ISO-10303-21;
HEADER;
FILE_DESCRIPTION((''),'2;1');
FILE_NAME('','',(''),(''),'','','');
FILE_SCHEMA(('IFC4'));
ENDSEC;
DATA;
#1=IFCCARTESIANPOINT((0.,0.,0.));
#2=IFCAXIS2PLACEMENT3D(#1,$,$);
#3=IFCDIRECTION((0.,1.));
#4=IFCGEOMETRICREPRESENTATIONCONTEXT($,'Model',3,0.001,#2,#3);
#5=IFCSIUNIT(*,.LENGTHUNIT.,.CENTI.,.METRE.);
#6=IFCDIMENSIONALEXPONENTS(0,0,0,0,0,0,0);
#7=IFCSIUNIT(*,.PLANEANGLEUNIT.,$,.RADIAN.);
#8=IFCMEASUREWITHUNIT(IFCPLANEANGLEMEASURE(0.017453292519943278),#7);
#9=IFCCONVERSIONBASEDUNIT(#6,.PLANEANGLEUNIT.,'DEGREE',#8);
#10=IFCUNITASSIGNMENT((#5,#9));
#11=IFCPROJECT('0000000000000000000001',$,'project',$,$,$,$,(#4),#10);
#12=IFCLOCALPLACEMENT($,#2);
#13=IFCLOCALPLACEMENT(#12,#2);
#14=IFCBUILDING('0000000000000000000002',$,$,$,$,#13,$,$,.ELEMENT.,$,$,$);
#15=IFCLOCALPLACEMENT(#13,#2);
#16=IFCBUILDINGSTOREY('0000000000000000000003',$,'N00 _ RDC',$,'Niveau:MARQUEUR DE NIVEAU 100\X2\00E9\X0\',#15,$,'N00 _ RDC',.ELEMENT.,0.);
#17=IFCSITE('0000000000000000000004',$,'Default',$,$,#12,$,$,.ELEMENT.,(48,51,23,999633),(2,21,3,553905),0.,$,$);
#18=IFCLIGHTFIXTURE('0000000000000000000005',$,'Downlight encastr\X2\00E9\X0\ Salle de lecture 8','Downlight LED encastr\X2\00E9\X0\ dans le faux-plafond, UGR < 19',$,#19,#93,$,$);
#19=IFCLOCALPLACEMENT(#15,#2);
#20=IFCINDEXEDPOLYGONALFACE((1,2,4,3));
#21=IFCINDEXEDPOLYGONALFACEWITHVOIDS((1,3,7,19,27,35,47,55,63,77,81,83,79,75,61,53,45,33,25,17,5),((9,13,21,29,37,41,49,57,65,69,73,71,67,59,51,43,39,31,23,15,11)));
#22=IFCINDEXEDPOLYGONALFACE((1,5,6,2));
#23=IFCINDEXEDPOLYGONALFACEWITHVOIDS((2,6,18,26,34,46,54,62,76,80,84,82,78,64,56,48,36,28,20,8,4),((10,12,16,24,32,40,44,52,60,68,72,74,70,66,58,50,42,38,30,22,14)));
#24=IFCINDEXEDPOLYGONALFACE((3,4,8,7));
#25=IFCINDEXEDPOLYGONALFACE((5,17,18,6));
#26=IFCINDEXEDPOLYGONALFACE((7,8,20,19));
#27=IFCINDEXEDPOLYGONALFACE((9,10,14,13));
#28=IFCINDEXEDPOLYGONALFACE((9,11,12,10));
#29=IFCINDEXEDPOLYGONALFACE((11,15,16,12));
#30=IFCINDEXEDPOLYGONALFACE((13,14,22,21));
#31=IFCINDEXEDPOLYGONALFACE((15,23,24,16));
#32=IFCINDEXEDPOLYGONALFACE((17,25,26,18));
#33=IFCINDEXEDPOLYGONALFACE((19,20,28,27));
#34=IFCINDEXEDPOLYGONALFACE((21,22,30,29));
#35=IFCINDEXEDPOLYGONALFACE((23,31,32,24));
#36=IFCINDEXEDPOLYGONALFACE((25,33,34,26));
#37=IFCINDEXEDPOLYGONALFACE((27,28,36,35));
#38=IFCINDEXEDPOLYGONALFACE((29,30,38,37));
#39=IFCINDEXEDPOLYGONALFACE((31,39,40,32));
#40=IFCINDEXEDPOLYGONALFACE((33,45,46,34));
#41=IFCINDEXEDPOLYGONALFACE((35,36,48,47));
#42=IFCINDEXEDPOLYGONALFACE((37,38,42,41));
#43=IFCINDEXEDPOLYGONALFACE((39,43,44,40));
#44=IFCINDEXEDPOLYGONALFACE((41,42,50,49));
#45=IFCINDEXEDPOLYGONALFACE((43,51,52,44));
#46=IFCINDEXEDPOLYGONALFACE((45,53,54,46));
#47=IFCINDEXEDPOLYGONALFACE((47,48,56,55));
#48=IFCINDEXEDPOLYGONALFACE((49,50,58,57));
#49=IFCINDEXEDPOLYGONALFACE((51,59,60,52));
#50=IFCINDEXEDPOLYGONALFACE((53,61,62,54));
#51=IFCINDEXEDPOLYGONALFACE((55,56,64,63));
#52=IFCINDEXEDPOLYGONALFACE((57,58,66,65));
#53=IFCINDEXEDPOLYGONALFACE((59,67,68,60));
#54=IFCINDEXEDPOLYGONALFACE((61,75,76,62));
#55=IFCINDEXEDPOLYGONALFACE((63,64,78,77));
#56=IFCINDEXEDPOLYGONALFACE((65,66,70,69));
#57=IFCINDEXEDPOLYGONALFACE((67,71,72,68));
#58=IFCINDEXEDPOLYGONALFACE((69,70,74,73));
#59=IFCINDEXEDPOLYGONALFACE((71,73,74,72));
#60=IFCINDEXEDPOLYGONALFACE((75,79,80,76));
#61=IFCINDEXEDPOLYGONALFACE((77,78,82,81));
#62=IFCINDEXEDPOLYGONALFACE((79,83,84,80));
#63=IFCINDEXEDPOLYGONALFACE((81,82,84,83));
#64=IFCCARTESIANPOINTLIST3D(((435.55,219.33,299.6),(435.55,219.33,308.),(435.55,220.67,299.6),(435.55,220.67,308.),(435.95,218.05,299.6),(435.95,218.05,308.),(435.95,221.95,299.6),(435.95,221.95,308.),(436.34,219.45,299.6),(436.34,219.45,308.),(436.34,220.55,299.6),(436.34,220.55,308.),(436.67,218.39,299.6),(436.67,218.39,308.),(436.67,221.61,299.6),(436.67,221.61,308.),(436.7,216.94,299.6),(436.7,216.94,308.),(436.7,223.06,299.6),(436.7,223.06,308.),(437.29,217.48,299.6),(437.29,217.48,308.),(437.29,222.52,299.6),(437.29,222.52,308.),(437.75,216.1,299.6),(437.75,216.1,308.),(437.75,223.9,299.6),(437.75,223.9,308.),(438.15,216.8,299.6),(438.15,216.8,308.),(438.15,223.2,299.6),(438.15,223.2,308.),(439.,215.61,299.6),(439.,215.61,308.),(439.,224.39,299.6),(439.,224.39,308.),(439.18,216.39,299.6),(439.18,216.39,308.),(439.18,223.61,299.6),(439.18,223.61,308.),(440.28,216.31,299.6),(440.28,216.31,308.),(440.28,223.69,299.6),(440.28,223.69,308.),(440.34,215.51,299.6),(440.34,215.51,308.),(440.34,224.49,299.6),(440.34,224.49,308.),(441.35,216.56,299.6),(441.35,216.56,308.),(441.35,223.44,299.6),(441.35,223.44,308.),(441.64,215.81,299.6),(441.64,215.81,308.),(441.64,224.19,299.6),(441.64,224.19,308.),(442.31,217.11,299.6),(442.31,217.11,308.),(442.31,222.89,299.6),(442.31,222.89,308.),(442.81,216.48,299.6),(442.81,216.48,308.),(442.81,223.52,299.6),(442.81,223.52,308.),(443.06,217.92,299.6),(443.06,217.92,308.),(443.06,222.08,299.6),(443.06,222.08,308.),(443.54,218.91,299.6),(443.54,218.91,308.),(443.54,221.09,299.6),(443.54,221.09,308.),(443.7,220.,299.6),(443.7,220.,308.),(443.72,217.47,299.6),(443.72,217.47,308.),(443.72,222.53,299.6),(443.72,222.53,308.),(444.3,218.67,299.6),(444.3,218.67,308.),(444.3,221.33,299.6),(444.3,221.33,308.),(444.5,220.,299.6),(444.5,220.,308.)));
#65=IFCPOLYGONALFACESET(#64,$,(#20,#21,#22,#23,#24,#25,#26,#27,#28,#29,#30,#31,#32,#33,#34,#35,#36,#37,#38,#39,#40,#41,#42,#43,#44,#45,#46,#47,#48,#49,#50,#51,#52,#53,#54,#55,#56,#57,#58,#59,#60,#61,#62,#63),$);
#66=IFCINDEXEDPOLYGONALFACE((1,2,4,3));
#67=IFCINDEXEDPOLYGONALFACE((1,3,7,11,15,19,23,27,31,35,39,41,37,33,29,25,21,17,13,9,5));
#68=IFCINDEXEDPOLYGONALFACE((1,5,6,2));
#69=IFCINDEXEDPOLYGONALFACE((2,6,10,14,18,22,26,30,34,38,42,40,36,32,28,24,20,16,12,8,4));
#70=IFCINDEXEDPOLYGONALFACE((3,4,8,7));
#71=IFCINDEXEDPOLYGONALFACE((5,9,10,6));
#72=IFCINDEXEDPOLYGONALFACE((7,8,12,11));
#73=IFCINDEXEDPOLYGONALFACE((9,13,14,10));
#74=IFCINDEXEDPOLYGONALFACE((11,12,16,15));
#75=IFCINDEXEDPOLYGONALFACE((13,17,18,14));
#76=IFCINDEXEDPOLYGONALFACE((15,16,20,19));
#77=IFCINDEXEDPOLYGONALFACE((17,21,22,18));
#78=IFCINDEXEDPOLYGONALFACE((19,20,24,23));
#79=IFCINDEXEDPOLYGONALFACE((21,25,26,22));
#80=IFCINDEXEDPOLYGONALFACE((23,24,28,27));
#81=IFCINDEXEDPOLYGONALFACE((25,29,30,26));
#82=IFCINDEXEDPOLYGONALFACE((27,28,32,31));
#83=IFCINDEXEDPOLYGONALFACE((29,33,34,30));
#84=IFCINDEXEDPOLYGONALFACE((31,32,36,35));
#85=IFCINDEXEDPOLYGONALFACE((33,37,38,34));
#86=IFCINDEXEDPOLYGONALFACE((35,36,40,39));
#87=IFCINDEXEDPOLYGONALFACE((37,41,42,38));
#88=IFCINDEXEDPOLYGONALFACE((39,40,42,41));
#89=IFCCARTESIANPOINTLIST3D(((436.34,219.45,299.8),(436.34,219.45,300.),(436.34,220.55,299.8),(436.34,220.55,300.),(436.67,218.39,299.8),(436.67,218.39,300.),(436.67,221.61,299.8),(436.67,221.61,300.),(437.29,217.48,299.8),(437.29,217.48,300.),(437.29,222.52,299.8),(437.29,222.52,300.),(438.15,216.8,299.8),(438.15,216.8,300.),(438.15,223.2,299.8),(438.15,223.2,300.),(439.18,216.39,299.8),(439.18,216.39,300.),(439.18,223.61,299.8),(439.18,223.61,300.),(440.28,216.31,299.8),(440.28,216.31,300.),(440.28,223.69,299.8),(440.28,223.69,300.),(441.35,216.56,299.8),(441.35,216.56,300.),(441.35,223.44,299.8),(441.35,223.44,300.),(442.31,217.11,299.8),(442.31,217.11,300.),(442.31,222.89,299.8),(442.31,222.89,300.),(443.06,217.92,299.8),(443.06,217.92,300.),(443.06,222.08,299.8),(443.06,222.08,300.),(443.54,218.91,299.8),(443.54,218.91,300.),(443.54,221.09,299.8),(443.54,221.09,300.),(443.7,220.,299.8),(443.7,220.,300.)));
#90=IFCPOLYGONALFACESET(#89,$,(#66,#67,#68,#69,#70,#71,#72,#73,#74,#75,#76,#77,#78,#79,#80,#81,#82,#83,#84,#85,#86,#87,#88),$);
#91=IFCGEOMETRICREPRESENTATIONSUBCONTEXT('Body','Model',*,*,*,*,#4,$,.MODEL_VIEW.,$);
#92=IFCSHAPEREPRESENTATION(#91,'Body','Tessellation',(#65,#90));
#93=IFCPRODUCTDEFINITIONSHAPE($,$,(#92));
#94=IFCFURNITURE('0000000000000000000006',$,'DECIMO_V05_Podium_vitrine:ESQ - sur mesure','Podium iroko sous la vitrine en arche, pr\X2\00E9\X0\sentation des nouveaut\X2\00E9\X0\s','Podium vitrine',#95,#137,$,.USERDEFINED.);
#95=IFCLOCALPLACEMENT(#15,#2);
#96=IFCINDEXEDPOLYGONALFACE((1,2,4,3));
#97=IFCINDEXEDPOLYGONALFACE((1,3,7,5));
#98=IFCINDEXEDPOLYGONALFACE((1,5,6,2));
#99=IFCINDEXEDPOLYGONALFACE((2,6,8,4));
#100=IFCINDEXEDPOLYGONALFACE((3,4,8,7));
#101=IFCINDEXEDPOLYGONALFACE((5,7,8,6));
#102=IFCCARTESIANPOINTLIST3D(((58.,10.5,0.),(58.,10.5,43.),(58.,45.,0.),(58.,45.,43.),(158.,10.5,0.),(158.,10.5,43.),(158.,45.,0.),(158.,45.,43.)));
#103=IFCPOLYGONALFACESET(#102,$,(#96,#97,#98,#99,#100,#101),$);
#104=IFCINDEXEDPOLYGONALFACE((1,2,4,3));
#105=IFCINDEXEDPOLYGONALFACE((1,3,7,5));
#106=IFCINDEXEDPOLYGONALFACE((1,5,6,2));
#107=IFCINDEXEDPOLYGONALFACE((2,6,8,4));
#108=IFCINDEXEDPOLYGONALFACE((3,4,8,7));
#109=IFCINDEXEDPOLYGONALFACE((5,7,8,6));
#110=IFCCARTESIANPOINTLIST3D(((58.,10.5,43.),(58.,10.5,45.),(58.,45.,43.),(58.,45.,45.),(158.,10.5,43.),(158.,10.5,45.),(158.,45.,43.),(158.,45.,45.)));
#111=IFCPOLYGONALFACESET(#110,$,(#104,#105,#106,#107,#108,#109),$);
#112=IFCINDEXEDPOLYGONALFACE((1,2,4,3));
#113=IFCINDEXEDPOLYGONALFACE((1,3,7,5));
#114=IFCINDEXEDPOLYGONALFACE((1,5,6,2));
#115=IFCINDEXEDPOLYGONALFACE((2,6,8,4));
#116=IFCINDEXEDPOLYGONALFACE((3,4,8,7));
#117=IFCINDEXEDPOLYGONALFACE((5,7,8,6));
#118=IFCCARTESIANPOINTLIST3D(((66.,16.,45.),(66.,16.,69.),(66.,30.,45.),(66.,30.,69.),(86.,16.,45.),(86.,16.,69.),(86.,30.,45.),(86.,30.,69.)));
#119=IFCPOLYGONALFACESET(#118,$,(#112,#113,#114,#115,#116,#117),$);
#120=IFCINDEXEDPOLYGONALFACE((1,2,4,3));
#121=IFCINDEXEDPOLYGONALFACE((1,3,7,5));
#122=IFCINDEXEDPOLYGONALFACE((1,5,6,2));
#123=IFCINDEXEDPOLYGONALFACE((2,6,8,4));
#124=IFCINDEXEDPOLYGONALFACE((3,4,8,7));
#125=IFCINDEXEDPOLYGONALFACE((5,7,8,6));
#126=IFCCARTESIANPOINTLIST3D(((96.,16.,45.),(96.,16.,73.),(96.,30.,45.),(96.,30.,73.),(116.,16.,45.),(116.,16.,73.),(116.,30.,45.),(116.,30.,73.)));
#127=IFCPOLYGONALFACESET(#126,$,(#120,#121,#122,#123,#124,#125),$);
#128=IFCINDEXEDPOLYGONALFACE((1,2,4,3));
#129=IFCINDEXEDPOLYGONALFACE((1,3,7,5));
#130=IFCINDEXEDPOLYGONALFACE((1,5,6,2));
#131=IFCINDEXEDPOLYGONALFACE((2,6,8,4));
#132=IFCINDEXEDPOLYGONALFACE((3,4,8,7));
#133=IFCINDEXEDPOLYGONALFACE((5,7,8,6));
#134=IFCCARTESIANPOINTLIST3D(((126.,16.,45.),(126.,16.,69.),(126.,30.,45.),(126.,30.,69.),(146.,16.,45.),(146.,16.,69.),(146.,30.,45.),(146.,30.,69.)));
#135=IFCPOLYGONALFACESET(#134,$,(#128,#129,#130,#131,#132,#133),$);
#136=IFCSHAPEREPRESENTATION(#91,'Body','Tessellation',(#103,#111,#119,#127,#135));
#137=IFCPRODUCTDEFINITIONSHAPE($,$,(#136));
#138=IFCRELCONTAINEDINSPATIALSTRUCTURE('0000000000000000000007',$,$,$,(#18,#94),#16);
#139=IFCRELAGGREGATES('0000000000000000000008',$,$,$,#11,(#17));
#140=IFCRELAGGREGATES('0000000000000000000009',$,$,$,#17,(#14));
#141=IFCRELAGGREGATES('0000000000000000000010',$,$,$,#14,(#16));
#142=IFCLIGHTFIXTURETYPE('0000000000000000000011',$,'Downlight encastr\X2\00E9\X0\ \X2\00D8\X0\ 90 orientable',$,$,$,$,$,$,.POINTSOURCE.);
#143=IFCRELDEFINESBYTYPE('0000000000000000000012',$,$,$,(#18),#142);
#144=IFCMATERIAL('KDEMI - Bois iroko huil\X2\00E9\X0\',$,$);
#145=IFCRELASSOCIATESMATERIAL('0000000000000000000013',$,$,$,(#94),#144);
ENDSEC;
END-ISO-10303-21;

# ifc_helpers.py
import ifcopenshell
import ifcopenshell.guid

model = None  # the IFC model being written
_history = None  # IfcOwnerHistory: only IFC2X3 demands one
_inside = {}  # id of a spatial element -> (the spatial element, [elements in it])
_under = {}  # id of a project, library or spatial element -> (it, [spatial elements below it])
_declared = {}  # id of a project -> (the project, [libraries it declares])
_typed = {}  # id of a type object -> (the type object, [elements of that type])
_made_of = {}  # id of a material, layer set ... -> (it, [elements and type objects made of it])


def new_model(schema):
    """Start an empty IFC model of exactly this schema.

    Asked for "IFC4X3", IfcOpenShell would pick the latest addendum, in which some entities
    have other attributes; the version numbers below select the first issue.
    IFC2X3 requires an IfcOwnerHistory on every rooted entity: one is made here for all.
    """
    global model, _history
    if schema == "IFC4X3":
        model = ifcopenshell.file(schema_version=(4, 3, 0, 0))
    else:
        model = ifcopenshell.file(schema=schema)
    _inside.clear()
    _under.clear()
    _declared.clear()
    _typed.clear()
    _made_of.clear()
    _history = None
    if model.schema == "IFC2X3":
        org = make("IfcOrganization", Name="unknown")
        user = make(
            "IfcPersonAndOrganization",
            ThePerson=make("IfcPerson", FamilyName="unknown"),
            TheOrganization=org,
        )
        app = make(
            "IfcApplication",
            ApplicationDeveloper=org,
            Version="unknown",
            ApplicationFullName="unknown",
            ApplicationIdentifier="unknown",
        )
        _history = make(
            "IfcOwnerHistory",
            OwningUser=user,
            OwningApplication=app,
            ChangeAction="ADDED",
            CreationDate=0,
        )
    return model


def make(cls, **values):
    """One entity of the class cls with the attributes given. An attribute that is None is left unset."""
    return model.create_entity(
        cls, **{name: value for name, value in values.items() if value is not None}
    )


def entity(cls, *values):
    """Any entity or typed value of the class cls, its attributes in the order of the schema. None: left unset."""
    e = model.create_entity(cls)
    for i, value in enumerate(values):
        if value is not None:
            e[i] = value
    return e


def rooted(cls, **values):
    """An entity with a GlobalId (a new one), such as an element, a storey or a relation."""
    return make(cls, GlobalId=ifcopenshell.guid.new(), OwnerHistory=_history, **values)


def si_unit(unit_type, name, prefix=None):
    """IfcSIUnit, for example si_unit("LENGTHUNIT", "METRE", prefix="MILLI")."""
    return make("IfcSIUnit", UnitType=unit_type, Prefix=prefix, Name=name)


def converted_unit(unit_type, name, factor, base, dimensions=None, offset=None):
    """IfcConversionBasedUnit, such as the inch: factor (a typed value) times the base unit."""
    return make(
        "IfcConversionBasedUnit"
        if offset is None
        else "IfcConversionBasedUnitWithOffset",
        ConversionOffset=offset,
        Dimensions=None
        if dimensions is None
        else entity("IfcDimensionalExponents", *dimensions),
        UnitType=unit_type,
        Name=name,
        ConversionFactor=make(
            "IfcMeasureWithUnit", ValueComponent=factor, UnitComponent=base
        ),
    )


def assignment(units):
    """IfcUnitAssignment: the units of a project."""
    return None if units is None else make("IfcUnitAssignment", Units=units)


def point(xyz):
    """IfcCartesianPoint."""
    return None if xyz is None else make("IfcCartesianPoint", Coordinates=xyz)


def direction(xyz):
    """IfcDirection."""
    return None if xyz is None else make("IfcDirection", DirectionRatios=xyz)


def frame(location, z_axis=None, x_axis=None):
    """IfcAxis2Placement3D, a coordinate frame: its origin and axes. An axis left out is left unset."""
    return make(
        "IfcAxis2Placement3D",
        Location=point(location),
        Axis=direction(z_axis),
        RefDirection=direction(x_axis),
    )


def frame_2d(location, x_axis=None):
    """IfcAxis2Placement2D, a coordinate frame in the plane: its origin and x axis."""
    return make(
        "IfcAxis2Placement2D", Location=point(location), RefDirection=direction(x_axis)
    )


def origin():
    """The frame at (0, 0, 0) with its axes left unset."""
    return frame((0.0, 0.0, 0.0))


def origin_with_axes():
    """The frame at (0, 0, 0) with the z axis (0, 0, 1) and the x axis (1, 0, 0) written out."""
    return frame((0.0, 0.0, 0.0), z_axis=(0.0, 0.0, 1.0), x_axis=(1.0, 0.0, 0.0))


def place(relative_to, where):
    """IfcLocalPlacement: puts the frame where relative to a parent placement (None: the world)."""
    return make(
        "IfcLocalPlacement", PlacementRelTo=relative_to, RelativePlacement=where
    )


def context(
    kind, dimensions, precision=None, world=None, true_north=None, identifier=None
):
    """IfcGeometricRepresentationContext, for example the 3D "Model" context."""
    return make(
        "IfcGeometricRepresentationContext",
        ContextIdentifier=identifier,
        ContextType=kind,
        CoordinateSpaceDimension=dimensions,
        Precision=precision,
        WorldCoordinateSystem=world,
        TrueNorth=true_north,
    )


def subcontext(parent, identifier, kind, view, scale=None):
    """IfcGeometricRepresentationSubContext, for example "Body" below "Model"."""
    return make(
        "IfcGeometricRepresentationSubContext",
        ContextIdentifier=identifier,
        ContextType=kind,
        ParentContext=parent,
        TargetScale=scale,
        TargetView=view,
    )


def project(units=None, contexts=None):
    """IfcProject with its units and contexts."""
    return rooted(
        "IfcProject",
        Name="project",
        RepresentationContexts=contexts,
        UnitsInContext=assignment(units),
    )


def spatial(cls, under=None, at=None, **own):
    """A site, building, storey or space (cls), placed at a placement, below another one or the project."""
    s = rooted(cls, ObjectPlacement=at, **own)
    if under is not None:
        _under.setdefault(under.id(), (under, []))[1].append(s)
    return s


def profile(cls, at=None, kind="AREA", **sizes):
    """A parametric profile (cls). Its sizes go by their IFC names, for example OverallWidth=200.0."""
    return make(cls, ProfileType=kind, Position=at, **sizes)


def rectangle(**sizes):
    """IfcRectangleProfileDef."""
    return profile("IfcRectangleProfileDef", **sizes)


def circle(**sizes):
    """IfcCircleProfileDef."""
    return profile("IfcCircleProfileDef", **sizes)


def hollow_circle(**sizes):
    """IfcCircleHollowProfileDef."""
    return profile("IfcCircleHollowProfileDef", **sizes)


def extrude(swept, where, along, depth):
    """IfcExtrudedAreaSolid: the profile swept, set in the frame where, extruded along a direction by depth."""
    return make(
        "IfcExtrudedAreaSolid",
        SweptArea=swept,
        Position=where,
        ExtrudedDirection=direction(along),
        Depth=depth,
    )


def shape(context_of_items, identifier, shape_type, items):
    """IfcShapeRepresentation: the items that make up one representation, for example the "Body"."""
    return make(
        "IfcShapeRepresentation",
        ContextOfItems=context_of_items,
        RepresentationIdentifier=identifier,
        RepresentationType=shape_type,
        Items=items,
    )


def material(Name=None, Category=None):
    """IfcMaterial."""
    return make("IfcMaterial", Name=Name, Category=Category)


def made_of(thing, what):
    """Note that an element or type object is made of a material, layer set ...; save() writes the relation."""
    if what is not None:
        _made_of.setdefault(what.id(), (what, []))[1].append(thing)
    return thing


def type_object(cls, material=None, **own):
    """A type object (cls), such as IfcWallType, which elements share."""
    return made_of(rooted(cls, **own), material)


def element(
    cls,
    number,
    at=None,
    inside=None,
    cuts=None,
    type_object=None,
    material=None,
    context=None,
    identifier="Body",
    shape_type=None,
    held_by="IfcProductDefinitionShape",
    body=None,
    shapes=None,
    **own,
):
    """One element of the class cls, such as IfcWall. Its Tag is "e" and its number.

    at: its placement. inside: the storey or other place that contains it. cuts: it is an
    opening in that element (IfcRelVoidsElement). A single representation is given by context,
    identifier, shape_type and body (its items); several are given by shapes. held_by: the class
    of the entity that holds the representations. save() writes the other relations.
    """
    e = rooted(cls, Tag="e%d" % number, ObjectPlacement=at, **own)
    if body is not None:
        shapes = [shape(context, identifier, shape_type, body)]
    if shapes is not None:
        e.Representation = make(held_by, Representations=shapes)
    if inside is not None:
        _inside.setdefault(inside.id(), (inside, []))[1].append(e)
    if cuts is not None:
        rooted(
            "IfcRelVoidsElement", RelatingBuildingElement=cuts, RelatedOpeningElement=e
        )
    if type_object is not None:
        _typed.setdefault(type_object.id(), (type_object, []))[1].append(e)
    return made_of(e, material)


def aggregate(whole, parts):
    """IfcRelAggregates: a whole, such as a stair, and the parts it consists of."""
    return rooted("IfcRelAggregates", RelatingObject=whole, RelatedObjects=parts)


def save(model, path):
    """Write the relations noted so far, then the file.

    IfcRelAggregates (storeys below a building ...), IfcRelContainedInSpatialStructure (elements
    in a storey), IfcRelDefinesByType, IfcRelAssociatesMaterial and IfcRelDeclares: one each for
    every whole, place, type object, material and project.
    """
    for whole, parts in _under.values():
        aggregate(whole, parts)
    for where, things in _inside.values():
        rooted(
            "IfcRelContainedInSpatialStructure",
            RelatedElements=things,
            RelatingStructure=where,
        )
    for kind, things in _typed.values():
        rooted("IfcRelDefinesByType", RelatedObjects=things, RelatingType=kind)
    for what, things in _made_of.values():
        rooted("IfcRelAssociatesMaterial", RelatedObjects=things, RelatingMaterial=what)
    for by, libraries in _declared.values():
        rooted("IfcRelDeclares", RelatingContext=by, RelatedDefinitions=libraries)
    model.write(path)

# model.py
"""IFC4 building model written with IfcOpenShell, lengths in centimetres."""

from ifc_helpers import new_model, entity, si_unit, converted_unit, direction, frame, frame_2d, origin, origin_with_axes, place, context, subcontext, project, spatial, rectangle, circle, hollow_circle, extrude, material, type_object, element, save


model = new_model("IFC4")

# Units and contexts
model_context = context("Model", 3, precision=0.001, world=origin(), true_north=direction((0.0, 1.0)))
body_context = subcontext(model_context, "Body", "Model", "MODEL_VIEW")
ifc_project = project(units=[si_unit("LENGTHUNIT", "METRE", prefix="CENTI"), converted_unit("PLANEANGLEUNIT", "DEGREE", entity("IfcPlaneAngleMeasure", 0.017453292519943278), si_unit("PLANEANGLEUNIT", "RADIAN"), dimensions=[0, 0, 0, 0, 0, 0, 0])], contexts=[model_context])

# Site, building, storey
site_placement = place(None, origin())
site = spatial("IfcSite", under=ifc_project, at=site_placement, Name="Default", CompositionType="ELEMENT", RefLatitude=(48, 51, 23, 999633), RefLongitude=(2, 21, 3, 553905), RefElevation=0.0)
building_placement = place(site_placement, origin())
building = spatial("IfcBuilding", under=site, at=building_placement, CompositionType="ELEMENT")
storey_placement = place(building_placement, origin())
storey = spatial("IfcBuildingStorey", under=building, at=storey_placement, Name="N00 _ RDC", ObjectType="Niveau:MARQUEUR DE NIVEAU 100é", LongName="N00 _ RDC", CompositionType="ELEMENT", Elevation=0.0)

# Shared definitions
ifc_material_1 = material(Name="KDEMI - Bois iroko huilé")

# Light fixture
light_fixture_type_1 = type_object("IfcLightFixtureType", Name="Downlight encastré Ø 90 orientable", PredefinedType="POINTSOURCE")
light_fixture_1_placement = place(storey_placement, origin_with_axes())
element("IfcLightFixture", 1, at=light_fixture_1_placement, inside=storey, type_object=light_fixture_type_1, Name="Downlight encastré Salle de lecture 8", Description="Downlight LED encastré dans le faux-plafond, UGR < 19", context=body_context, shape_type="SweptSolid", body=[
    extrude(hollow_circle(Radius=4.5, WallThickness=0.8, at=frame_2d((440.0, 220.0))), frame((0.0, 0.0, 299.6)), (0.0, 0.0, 1.0), 8.4),
    extrude(circle(Radius=3.7, at=frame_2d((440.0, 220.0))), frame((0.0, 0.0, 299.8)), (0.0, 0.0, 1.0), 0.2),
])

# Furniture
furniture_1_placement = place(storey_placement, origin_with_axes())
element("IfcFurniture", 2, at=furniture_1_placement, inside=storey, material=ifc_material_1, Name="DECIMO_V05_Podium_vitrine:ESQ - sur mesure", Description="Podium iroko sous la vitrine en arche, présentation des nouveautés", ObjectType="Podium vitrine", PredefinedType="USERDEFINED", context=body_context, shape_type="SweptSolid", body=[
    extrude(rectangle(XDim=100.0, YDim=34.5, at=frame_2d((108.0, 27.75))), origin(), (0.0, 0.0, 1.0), 43.0),
    extrude(rectangle(XDim=100.0, YDim=34.5, at=frame_2d((108.0, 27.75))), frame((0.0, 0.0, 43.0)), (0.0, 0.0, 1.0), 2.0),
    extrude(rectangle(XDim=20.0, YDim=14.0, at=frame_2d((76.0, 23.0))), frame((0.0, 0.0, 45.0)), (0.0, 0.0, 1.0), 24.0),
    extrude(rectangle(XDim=20.0, YDim=14.0, at=frame_2d((106.0, 23.0))), frame((0.0, 0.0, 45.0)), (0.0, 0.0, 1.0), 28.0),
    extrude(rectangle(XDim=20.0, YDim=14.0, at=frame_2d((136.0, 23.0))), frame((0.0, 0.0, 45.0)), (0.0, 0.0, 1.0), 24.0),
])

save(model, "model.ifc")
